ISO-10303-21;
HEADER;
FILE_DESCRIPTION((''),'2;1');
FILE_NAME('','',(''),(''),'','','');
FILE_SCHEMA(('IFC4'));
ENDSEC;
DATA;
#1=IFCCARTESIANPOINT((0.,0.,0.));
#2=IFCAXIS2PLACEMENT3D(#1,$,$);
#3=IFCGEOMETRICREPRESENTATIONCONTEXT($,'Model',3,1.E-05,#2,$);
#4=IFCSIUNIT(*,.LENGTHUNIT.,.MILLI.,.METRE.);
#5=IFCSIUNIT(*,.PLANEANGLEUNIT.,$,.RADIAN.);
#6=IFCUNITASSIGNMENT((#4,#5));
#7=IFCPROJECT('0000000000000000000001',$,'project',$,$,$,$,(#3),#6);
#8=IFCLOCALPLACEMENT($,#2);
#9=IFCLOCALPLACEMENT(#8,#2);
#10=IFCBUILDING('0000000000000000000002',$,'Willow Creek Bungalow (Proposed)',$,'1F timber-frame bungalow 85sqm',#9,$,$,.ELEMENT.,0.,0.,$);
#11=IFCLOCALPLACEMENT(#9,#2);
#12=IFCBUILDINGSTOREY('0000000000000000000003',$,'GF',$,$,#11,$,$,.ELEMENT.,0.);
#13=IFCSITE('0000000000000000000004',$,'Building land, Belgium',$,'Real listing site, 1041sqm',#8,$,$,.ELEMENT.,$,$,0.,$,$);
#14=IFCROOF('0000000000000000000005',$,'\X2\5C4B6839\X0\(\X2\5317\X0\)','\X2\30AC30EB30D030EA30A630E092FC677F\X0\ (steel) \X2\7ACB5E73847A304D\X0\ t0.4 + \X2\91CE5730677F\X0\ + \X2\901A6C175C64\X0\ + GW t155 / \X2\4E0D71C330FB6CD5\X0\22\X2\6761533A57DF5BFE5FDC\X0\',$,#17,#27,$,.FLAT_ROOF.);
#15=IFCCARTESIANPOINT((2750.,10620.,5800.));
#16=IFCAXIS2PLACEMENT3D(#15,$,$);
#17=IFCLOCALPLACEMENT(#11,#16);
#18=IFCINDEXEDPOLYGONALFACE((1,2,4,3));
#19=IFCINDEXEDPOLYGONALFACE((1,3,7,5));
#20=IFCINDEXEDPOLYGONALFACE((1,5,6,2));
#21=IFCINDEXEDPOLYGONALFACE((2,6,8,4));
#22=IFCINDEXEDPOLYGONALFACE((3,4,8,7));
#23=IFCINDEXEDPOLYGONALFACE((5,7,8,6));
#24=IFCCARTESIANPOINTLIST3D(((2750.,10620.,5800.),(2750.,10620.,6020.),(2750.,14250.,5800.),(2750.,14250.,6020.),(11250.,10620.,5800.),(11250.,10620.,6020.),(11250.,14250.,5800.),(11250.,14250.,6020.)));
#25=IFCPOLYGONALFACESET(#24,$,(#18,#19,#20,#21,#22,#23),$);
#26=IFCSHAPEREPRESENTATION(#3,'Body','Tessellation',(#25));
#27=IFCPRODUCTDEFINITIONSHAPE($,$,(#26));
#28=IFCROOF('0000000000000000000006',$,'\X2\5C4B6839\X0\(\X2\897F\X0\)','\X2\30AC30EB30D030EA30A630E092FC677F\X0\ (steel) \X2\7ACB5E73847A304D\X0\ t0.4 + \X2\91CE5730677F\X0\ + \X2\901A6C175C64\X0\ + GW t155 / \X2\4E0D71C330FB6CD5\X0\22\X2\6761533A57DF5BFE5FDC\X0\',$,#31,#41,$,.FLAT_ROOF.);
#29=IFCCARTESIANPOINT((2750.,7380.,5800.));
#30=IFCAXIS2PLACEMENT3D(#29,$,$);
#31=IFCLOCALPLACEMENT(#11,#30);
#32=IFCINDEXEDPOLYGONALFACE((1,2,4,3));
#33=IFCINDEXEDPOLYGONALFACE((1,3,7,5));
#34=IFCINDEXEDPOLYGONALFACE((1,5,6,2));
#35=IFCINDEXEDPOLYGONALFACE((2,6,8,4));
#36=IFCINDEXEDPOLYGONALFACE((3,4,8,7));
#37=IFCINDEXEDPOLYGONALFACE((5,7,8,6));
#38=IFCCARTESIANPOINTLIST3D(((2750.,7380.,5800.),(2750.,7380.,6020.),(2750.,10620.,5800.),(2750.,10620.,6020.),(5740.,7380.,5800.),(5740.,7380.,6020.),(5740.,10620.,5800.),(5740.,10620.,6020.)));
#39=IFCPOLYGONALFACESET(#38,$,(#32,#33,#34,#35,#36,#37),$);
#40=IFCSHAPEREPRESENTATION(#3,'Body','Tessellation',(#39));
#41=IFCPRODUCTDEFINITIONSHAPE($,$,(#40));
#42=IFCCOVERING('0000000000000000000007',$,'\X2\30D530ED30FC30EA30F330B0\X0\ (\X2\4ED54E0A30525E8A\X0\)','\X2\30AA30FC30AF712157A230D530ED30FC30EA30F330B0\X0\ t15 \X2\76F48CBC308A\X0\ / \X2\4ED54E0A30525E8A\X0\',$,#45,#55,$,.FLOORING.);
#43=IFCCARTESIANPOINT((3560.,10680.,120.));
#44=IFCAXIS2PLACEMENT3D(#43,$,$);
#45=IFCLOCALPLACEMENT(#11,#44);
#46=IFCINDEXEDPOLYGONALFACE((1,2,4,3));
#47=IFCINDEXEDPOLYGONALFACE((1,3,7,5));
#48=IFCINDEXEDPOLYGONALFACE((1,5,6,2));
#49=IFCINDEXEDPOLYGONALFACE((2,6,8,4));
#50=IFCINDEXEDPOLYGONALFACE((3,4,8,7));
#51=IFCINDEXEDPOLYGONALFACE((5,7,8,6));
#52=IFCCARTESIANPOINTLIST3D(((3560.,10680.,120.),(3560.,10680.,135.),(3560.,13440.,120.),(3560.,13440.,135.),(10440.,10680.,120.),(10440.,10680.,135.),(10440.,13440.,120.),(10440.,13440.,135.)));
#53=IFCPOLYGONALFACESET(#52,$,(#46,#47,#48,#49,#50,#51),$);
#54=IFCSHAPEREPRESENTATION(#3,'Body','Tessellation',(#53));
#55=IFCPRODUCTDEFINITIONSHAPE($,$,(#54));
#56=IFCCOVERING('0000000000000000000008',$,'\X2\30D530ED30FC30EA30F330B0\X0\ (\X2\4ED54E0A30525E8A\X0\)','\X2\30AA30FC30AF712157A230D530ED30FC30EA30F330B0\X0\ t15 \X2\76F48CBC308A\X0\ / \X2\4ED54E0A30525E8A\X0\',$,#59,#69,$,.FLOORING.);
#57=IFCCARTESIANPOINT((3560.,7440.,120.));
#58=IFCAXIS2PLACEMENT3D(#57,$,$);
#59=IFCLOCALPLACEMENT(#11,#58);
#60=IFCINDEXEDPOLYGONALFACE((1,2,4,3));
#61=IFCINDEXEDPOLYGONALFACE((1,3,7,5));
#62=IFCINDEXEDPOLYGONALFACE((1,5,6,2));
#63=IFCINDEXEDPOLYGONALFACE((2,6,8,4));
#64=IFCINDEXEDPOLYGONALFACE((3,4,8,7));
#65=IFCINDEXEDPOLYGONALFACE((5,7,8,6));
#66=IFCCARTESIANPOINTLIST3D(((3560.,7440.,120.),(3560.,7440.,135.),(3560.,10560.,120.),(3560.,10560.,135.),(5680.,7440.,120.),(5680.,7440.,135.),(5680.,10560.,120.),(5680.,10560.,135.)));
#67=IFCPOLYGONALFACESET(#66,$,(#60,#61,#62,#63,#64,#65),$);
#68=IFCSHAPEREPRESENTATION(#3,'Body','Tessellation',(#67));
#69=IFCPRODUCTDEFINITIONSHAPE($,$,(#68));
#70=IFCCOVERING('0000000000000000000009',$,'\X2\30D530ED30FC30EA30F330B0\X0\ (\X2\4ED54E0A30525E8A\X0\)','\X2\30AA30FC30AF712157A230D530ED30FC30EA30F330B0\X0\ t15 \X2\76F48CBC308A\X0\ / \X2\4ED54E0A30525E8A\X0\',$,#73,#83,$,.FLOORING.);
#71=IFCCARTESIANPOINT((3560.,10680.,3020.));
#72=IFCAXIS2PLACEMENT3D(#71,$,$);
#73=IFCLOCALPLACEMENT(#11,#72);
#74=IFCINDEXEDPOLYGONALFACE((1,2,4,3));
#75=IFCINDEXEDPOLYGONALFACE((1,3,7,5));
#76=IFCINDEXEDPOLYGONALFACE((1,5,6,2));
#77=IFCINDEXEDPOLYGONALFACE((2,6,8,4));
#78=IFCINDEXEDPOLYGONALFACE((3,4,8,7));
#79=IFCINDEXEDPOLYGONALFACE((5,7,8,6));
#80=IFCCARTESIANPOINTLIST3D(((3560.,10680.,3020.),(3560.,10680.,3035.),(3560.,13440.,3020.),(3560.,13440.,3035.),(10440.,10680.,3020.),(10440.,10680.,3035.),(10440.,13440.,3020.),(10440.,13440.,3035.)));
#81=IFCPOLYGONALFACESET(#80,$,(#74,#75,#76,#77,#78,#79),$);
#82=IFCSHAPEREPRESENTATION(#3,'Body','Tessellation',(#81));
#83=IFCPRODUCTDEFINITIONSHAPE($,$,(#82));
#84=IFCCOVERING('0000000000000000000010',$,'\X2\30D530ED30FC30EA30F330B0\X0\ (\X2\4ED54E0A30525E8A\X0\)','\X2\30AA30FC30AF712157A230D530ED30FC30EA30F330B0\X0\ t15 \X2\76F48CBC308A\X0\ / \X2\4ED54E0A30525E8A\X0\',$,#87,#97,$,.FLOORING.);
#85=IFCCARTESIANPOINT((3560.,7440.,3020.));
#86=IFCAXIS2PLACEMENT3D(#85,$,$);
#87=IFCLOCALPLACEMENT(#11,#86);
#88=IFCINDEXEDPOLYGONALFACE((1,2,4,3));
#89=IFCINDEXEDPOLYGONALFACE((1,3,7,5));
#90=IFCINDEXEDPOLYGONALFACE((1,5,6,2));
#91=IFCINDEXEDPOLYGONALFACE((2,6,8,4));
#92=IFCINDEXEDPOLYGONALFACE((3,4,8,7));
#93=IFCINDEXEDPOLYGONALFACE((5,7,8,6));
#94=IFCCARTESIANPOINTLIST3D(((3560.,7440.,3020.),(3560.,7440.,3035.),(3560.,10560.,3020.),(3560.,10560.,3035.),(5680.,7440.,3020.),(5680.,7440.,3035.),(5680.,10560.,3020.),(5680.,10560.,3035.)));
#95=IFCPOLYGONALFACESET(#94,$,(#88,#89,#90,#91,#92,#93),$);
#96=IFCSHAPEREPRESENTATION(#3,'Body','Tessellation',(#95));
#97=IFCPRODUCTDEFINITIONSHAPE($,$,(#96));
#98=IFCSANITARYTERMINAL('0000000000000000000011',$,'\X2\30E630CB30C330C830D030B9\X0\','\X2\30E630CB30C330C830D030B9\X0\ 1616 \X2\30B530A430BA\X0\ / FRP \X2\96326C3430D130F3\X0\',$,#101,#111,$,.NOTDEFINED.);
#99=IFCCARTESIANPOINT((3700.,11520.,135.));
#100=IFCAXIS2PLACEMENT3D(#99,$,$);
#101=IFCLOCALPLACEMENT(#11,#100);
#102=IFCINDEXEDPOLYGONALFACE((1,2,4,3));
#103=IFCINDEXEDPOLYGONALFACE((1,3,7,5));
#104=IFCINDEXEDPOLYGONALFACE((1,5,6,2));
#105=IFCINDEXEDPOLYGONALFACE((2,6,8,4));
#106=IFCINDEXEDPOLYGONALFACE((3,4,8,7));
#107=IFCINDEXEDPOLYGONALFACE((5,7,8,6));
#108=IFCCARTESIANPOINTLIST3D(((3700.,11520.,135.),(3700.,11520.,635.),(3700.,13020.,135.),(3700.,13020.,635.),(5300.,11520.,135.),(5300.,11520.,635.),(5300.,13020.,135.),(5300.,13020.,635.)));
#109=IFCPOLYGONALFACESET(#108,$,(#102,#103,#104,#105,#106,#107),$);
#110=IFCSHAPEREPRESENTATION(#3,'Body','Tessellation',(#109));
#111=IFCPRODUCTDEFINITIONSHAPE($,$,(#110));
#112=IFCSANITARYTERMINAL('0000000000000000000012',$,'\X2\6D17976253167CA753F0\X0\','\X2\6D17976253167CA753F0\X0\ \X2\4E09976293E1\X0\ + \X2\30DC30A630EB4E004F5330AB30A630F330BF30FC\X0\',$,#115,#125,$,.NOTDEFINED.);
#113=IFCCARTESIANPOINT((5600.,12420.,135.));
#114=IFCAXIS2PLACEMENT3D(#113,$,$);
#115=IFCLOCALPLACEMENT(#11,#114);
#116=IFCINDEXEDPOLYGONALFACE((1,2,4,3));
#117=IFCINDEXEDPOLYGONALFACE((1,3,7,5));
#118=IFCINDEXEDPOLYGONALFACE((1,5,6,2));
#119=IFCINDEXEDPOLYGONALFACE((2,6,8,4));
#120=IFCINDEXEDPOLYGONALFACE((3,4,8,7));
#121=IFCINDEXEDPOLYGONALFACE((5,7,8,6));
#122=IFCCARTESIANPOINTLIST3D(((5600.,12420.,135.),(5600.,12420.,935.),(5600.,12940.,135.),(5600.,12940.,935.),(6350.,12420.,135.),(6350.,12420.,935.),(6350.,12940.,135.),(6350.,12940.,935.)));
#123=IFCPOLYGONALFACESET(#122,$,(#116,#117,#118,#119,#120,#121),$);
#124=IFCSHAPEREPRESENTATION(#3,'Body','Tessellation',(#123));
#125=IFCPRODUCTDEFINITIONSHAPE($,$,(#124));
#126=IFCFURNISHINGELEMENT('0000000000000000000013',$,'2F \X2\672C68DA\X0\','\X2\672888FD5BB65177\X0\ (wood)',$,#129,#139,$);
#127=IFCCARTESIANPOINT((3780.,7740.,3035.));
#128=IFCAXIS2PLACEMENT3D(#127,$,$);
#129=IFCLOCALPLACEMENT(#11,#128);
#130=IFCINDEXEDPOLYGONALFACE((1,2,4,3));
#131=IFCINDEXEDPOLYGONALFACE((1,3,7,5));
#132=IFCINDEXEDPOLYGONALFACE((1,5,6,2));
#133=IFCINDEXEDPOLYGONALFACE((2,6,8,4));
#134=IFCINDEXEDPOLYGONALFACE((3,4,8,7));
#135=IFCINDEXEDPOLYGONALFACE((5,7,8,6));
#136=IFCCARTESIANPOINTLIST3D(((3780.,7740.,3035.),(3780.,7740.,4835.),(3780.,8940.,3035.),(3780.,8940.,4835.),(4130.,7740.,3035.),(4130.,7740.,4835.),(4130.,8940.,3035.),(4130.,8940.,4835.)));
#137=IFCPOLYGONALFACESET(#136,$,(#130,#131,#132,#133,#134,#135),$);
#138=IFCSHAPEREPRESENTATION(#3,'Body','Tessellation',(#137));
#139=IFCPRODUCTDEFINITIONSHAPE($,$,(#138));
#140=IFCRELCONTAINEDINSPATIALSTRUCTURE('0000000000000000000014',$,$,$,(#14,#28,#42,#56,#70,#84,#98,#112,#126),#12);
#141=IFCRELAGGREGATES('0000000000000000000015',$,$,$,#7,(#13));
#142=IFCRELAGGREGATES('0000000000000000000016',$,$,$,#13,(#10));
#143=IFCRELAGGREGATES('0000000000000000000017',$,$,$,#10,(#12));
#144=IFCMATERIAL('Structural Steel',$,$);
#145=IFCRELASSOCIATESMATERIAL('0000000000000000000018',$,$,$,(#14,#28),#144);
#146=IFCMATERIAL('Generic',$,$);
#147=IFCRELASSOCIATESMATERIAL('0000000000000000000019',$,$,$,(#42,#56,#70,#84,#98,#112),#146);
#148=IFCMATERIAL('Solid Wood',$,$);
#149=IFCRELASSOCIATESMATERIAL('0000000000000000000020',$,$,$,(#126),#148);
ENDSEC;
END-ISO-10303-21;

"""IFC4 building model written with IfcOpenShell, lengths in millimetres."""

from ifc_helpers import new_model, si_unit, frame, frame_2d, origin, place, context, project, spatial, rectangle, extrude, material, element, save


model = new_model("IFC4")

# Units and contexts
model_context = context("Model", 3, precision=1e-05, world=origin())
ifc_project = project(units=[si_unit("LENGTHUNIT", "METRE", prefix="MILLI"), si_unit("PLANEANGLEUNIT", "RADIAN")], contexts=[model_context])

# Site, building, storey
site_placement = place(None, origin())
site = spatial("IfcSite", under=ifc_project, at=site_placement, Name="Building land, Belgium", ObjectType="Real listing site, 1041sqm", CompositionType="ELEMENT", RefElevation=0.0)
building_placement = place(site_placement, origin())
building = spatial("IfcBuilding", under=site, at=building_placement, Name="Willow Creek Bungalow (Proposed)", ObjectType="1F timber-frame bungalow 85sqm", CompositionType="ELEMENT", ElevationOfRefHeight=0.0, ElevationOfTerrain=0.0)
storey_placement = place(building_placement, origin())
storey = spatial("IfcBuildingStorey", under=building, at=storey_placement, Name="GF", CompositionType="ELEMENT", Elevation=0.0)

# Shared definitions
ifc_material_1 = material(Name="Solid Wood")

# Roofs
ifc_material_2 = material(Name="Structural Steel")
for number, where, name in (
    (1, (2750.0, 10620.0, 5800.0), "屋根(北)"),
):
    element("IfcRoof", number, at=place(storey_placement, frame(where)), inside=storey, material=ifc_material_2, Name=name, Description="ガルバリウム鋼板 (steel) 立平葺き t0.4 + 野地板 + 通気層 + GW t155 / 不燃・法22条区域対応", PredefinedType="FLAT_ROOF", context=model_context, shape_type="SweptSolid", body=[
        extrude(rectangle(XDim=8500.0, YDim=3630.0, at=frame_2d((4250.0, 1815.0))), frame((2750.0, 10620.0, 5800.0)), (0.0, 0.0, 1.0), 220.0),
    ])
roof_placement = place(storey_placement, frame((2750.0, 7380.0, 5800.0)))
element("IfcRoof", 2, at=roof_placement, inside=storey, material=ifc_material_2, Name="屋根(西)", Description="ガルバリウム鋼板 (steel) 立平葺き t0.4 + 野地板 + 通気層 + GW t155 / 不燃・法22条区域対応", PredefinedType="FLAT_ROOF", context=model_context, shape_type="SweptSolid", body=[
    extrude(rectangle(XDim=2990.0, YDim=3240.0, at=frame_2d((1495.0, 1620.0))), frame((2750.0, 7380.0, 5800.0)), (0.0, 0.0, 1.0), 220.0),
])

# Coverings
ifc_material_3 = material(Name="Generic")
covering_1_placement = place(storey_placement, frame((3560.0, 10680.0, 120.0)))
element("IfcCovering", 3, at=covering_1_placement, inside=storey, material=ifc_material_3, Name="フローリング (仕上げ床)", Description="オーク無垢フローリング t15 直貼り / 仕上げ床", PredefinedType="FLOORING", context=model_context, shape_type="SweptSolid", body=[
    extrude(rectangle(XDim=6880.0, YDim=2760.0, at=frame_2d((3440.0, 1380.0))), frame((3560.0, 10680.0, 120.0)), (0.0, 0.0, 1.0), 15.0),
])
covering_2_placement = place(storey_placement, frame((3560.0, 7440.0, 120.0)))
element("IfcCovering", 4, at=covering_2_placement, inside=storey, material=ifc_material_3, Name="フローリング (仕上げ床)", Description="オーク無垢フローリング t15 直貼り / 仕上げ床", PredefinedType="FLOORING", context=model_context, shape_type="SweptSolid", body=[
    extrude(rectangle(XDim=2120.0, YDim=3120.0, at=frame_2d((1060.0, 1560.0))), frame((3560.0, 7440.0, 120.0)), (0.0, 0.0, 1.0), 15.0),
])
covering_3_placement = place(storey_placement, frame((3560.0, 10680.0, 3020.0)))
element("IfcCovering", 5, at=covering_3_placement, inside=storey, material=ifc_material_3, Name="フローリング (仕上げ床)", Description="オーク無垢フローリング t15 直貼り / 仕上げ床", PredefinedType="FLOORING", context=model_context, shape_type="SweptSolid", body=[
    extrude(rectangle(XDim=6880.0, YDim=2760.0, at=frame_2d((3440.0, 1380.0))), frame((3560.0, 10680.0, 3020.0)), (0.0, 0.0, 1.0), 15.0),
])
covering_4_placement = place(storey_placement, frame((3560.0, 7440.0, 3020.0)))
element("IfcCovering", 6, at=covering_4_placement, inside=storey, material=ifc_material_3, Name="フローリング (仕上げ床)", Description="オーク無垢フローリング t15 直貼り / 仕上げ床", PredefinedType="FLOORING", context=model_context, shape_type="SweptSolid", body=[
    extrude(rectangle(XDim=2120.0, YDim=3120.0, at=frame_2d((1060.0, 1560.0))), frame((3560.0, 7440.0, 3020.0)), (0.0, 0.0, 1.0), 15.0),
])

# Sanitary terminals
sanitary_terminal_1_placement = place(storey_placement, frame((3700.0, 11520.0, 135.0)))
element("IfcSanitaryTerminal", 7, at=sanitary_terminal_1_placement, inside=storey, material=ifc_material_3, Name="ユニットバス", Description="ユニットバス 1616 サイズ / FRP 防水パン", PredefinedType="NOTDEFINED", context=model_context, shape_type="SweptSolid", body=[
    extrude(rectangle(XDim=1600.0, YDim=1500.0, at=frame_2d((800.0, 750.0))), frame((3700.0, 11520.0, 135.0)), (0.0, 0.0, 1.0), 500.0),
])
sanitary_terminal_2_placement = place(storey_placement, frame((5600.0, 12420.0, 135.0)))
element("IfcSanitaryTerminal", 8, at=sanitary_terminal_2_placement, inside=storey, material=ifc_material_3, Name="洗面化粧台", Description="洗面化粧台 三面鏡 + ボウル一体カウンター", PredefinedType="NOTDEFINED", context=model_context, shape_type="SweptSolid", body=[
    extrude(rectangle(XDim=750.0, YDim=520.0, at=frame_2d((375.0, 260.0))), frame((5600.0, 12420.0, 135.0)), (0.0, 0.0, 1.0), 800.0),
])

# Furnishing element
furnishing_placement = place(storey_placement, frame((3780.0, 7740.0, 3035.0)))
element("IfcFurnishingElement", 9, at=furnishing_placement, inside=storey, material=ifc_material_1, Name="2F 本棚", Description="木製家具 (wood)", context=model_context, shape_type="SweptSolid", body=[
    extrude(rectangle(XDim=350.0, YDim=1200.0, at=frame_2d((175.0, 600.0))), frame((3780.0, 7740.0, 3035.0)), (0.0, 0.0, 1.0), 1800.0),
])

save(model, "model.ifc")
